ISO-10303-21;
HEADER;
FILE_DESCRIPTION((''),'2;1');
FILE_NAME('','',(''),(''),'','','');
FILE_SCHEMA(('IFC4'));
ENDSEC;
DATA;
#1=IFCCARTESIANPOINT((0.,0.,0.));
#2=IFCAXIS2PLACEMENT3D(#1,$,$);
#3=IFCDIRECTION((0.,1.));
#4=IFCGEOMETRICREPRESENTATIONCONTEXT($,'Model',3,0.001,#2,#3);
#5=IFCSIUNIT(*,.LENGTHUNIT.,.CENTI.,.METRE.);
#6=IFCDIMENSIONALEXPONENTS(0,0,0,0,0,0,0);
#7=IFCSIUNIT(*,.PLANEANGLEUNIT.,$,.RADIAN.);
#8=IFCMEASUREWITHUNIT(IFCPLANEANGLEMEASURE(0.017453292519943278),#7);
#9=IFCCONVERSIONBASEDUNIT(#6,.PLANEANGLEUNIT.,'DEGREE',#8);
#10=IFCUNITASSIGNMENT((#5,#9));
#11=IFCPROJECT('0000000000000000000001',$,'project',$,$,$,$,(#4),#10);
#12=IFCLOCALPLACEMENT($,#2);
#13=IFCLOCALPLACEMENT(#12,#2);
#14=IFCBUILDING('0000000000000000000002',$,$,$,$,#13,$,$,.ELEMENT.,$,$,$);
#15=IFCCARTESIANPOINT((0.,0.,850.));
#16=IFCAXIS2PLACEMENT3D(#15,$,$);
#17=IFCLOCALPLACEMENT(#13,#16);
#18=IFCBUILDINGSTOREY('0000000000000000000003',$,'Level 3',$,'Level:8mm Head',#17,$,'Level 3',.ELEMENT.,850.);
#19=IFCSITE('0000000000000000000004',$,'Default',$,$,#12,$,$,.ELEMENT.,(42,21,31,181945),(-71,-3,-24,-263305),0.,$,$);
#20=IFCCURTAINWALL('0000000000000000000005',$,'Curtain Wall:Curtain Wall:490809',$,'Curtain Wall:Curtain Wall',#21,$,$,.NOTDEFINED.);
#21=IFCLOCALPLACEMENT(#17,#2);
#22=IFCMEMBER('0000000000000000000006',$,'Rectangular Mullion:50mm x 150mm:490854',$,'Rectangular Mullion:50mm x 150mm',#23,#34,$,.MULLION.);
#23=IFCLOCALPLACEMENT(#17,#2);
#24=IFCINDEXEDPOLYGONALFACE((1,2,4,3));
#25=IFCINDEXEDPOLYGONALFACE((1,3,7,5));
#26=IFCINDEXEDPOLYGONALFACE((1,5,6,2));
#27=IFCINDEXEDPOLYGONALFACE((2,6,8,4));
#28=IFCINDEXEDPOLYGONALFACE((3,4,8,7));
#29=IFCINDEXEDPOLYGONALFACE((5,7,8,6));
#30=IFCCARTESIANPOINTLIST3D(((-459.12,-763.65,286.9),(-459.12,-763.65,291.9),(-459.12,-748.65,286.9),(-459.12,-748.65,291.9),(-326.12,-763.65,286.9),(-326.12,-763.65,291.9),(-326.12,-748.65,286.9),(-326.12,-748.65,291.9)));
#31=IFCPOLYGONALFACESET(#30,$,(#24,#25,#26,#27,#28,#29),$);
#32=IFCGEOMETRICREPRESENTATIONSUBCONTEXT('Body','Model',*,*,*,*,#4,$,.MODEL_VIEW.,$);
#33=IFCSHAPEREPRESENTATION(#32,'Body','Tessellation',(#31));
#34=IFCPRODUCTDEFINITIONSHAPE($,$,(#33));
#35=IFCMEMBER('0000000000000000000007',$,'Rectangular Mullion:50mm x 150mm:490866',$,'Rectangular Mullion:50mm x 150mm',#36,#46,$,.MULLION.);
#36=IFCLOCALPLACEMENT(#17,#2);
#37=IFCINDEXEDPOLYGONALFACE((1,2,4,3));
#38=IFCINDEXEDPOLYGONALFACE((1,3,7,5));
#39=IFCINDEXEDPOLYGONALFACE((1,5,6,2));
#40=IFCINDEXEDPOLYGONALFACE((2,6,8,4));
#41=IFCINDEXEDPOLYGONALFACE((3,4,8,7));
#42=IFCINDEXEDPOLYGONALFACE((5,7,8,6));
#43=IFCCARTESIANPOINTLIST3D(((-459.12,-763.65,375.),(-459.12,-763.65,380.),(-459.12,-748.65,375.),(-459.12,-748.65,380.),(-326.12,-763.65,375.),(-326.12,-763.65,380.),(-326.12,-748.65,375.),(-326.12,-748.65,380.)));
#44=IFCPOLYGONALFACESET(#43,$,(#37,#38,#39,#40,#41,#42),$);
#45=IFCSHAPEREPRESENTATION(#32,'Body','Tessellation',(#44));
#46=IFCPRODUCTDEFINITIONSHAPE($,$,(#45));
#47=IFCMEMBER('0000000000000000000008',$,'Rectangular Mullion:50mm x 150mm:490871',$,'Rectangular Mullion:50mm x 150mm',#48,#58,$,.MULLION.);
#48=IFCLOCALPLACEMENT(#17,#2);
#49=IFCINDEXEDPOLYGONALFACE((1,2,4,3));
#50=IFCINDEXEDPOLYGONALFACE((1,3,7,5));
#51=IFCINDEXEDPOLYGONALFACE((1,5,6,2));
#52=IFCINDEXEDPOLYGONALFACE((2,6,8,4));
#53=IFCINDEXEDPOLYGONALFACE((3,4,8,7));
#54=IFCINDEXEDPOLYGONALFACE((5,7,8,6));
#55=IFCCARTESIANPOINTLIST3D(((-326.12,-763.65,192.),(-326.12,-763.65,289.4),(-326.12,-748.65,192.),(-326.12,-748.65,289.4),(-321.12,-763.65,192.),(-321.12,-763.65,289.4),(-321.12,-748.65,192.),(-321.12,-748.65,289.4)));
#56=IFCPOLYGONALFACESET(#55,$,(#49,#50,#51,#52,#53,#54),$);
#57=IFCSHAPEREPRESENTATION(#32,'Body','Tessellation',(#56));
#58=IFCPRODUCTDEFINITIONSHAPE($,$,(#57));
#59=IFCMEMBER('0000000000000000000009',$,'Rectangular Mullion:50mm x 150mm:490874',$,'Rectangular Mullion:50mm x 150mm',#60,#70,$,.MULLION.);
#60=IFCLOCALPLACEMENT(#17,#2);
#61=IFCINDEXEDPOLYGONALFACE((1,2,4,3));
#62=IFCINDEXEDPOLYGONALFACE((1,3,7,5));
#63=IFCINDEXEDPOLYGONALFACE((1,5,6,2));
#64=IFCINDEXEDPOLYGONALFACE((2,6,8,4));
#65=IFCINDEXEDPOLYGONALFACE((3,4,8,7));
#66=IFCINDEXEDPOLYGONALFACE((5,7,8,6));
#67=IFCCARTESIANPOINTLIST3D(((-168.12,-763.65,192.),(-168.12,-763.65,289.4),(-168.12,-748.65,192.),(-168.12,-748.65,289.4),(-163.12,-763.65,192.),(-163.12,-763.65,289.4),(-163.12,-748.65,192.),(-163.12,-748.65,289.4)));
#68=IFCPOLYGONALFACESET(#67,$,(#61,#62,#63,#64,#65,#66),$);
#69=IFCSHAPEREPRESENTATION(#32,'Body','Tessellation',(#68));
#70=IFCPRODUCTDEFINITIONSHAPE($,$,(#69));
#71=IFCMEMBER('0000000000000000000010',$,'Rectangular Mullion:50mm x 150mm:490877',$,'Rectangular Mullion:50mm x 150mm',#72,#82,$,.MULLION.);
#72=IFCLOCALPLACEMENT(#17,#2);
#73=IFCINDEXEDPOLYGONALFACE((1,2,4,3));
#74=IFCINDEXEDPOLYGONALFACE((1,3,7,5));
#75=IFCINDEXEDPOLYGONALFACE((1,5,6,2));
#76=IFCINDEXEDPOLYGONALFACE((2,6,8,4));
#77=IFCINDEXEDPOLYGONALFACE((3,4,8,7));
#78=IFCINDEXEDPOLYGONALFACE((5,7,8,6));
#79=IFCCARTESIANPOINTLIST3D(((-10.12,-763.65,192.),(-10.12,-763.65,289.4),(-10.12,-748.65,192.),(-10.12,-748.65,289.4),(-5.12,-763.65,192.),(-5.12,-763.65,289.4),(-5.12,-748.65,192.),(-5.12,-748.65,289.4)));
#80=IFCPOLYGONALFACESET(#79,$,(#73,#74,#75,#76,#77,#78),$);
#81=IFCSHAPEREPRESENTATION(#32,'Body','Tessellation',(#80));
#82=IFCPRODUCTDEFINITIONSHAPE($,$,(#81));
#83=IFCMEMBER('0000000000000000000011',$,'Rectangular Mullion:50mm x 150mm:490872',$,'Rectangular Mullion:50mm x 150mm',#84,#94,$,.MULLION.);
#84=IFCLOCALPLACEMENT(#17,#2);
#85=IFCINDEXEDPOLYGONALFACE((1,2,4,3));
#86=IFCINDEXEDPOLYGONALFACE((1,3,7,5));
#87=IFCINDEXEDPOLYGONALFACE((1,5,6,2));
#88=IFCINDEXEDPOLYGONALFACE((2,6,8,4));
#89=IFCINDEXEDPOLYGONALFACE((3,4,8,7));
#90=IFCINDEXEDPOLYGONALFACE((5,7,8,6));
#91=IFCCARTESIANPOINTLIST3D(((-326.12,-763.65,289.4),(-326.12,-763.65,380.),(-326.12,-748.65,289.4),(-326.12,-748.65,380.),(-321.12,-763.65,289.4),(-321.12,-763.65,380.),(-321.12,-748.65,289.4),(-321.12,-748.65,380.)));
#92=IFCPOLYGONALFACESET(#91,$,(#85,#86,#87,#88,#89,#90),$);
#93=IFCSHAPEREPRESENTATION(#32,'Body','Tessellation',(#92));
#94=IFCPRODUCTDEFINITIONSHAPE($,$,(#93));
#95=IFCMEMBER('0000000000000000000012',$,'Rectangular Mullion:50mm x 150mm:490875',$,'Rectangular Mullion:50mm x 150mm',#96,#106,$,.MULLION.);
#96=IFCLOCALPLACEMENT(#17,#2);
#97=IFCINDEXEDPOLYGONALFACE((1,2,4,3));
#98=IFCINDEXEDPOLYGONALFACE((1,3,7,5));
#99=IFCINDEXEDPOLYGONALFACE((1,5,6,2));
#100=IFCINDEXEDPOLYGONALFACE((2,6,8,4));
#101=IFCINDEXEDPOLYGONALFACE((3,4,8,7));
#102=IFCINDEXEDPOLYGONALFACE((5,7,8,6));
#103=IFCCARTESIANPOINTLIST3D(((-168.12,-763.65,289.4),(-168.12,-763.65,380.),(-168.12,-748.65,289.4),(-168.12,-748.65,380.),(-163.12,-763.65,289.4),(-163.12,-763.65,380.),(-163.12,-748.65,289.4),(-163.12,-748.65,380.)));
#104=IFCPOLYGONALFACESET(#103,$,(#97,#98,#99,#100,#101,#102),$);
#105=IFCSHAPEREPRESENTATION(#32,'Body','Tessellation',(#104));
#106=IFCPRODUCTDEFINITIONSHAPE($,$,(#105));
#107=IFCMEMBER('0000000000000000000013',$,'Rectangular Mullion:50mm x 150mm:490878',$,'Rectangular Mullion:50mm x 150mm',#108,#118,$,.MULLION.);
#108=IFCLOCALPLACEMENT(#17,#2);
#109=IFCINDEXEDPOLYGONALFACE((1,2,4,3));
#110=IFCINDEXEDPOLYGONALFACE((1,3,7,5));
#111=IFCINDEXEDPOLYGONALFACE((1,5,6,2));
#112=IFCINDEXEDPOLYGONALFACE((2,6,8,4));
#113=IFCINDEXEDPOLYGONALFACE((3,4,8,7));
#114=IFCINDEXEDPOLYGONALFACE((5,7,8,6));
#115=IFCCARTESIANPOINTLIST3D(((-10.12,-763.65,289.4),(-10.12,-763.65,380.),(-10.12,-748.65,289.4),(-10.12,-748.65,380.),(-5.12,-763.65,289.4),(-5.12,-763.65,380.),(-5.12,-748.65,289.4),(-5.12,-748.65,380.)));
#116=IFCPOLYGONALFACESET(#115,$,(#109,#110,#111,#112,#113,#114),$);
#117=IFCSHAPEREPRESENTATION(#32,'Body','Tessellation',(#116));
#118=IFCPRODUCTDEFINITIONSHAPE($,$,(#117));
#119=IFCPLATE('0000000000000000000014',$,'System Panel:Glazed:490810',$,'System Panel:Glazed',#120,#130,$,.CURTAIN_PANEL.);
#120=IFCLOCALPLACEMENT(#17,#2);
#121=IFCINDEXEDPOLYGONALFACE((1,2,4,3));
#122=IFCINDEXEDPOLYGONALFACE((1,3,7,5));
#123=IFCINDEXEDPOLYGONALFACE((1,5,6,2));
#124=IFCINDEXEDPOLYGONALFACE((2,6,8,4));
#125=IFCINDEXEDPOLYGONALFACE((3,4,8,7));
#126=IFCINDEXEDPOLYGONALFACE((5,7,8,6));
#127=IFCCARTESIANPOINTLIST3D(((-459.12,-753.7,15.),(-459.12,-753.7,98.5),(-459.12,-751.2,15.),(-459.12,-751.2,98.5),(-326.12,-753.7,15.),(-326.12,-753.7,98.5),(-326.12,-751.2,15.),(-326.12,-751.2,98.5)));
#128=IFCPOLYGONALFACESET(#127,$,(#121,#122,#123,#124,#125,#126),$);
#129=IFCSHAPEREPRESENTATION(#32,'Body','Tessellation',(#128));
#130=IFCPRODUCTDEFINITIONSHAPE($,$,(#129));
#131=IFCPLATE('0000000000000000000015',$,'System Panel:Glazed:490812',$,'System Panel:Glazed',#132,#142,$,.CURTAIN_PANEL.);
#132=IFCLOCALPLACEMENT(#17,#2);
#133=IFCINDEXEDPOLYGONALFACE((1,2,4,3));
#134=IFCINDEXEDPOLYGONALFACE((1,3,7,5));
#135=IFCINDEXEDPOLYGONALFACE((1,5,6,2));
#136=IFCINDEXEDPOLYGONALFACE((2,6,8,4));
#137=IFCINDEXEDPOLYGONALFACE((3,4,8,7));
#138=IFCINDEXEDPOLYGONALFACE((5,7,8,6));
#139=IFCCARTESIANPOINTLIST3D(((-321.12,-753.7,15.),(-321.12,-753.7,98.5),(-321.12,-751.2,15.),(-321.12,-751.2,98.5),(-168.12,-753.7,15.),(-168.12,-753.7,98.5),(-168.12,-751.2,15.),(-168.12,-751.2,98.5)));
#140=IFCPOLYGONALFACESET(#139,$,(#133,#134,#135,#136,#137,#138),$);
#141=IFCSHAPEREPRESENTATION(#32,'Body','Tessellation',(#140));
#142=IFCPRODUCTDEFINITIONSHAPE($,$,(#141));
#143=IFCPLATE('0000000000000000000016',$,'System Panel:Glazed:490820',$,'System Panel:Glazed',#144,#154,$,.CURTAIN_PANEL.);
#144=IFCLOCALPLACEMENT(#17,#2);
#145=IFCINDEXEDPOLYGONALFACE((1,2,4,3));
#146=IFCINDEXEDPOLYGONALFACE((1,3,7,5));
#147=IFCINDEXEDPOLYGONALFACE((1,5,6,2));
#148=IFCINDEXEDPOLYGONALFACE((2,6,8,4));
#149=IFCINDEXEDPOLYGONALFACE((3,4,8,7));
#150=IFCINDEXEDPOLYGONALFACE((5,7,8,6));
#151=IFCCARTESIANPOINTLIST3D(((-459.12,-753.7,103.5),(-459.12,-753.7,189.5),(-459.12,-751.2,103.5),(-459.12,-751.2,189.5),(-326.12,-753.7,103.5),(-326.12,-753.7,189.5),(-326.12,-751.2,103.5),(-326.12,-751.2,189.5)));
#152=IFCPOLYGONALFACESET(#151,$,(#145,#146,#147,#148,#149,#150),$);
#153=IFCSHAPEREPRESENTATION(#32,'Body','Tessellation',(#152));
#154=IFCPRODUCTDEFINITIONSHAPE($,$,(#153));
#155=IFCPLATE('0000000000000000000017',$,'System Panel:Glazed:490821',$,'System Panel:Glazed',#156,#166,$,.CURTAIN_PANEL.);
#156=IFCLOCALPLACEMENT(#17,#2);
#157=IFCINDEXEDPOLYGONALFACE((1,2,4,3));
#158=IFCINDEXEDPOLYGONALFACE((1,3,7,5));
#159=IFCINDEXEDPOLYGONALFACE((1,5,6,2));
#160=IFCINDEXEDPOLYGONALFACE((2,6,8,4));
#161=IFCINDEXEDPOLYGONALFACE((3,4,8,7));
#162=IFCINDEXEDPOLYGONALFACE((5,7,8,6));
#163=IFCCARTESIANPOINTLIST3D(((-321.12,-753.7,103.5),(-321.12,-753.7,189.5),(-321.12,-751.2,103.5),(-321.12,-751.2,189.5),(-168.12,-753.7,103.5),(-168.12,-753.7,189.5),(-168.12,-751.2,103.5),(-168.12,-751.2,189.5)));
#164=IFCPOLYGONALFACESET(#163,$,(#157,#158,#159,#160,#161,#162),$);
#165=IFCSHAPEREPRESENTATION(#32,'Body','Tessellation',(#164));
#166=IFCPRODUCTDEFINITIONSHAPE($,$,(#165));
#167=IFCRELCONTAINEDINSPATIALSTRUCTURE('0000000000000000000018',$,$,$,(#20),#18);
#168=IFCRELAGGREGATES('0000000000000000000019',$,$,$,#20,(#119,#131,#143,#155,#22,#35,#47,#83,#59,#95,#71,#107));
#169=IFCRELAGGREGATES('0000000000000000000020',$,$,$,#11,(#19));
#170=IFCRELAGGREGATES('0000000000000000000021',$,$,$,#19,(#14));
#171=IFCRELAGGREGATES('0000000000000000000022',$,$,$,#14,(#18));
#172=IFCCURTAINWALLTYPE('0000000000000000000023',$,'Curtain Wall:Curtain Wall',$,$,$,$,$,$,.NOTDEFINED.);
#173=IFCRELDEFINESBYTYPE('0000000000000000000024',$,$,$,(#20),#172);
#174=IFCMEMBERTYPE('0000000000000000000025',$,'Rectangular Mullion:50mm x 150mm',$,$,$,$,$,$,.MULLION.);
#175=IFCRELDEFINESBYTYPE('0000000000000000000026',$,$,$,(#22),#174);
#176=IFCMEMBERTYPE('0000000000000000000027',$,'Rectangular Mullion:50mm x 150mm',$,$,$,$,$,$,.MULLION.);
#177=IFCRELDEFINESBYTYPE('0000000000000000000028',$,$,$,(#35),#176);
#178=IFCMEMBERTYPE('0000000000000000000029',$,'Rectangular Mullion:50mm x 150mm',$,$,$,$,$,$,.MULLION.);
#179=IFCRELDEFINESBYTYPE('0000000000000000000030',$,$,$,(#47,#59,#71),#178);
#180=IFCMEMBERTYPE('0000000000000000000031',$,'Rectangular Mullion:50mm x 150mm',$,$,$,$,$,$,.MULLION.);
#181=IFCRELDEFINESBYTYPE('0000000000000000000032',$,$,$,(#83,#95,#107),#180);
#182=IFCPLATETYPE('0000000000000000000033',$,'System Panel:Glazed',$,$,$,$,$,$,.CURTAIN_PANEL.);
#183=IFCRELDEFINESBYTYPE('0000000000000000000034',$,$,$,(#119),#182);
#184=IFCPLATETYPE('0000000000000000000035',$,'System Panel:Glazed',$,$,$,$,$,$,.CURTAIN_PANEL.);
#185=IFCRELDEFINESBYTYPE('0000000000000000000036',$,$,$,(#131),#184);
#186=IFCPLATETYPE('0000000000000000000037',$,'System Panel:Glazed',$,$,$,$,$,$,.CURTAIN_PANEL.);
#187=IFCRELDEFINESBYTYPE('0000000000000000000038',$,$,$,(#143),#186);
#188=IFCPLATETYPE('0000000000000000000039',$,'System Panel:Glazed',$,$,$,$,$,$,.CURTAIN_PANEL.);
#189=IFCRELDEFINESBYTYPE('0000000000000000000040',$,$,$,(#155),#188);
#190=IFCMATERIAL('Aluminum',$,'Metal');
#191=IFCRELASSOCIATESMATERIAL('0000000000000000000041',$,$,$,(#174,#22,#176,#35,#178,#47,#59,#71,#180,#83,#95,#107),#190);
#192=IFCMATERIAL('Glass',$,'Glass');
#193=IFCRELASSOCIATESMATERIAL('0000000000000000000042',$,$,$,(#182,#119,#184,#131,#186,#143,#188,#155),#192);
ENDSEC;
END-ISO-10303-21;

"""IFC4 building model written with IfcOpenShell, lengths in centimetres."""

from ifc_helpers import new_model, entity, si_unit, converted_unit, direction, frame, origin, place, context, subcontext, project, spatial, indexed_curve, outline, extrude, source, transform, mapped, material, type_object, type_shapes, element, aggregate, save


model = new_model("IFC4")

# Units and contexts
model_context = context("Model", 3, precision=0.001, world=origin(), true_north=direction((0.0, 1.0)))
body_context = subcontext(model_context, "Body", "Model", "MODEL_VIEW")
ifc_project = project(units=[si_unit("LENGTHUNIT", "METRE", prefix="CENTI"), converted_unit("PLANEANGLEUNIT", "DEGREE", entity("IfcPlaneAngleMeasure", 0.017453292519943278), si_unit("PLANEANGLEUNIT", "RADIAN"), dimensions=[0, 0, 0, 0, 0, 0, 0])], contexts=[model_context])

# Site, building, storey
site_placement = place(None, origin())
site = spatial("IfcSite", under=ifc_project, at=site_placement, Name="Default", CompositionType="ELEMENT", RefLatitude=(42, 21, 31, 181945), RefLongitude=(-71, -3, -24, -263305), RefElevation=0.0)
building_placement = place(site_placement, origin())
building = spatial("IfcBuilding", under=site, at=building_placement, CompositionType="ELEMENT")
storey_placement = place(building_placement, frame((0.0, 0.0, 850.0)))
storey = spatial("IfcBuildingStorey", under=building, at=storey_placement, Name="Level 3", ObjectType="Level:8mm Head", LongName="Level 3", CompositionType="ELEMENT", Elevation=850.0)

# Curtain wall, members, plates
curtain_wall_type = type_object("IfcCurtainWallType", Name="Curtain Wall:Curtain Wall", PredefinedType="NOTDEFINED")
curtain_wall_placement = place(storey_placement, frame((0.0, 0.0, -850.0)))
curtain_wall = element("IfcCurtainWall", 1, at=curtain_wall_placement, inside=storey, type_object=curtain_wall_type, Name="Curtain Wall:Curtain Wall:490809", ObjectType="Curtain Wall:Curtain Wall", PredefinedType="NOTDEFINED")
ifc_material_1 = material(Name="Aluminum", Category="Metal")
member_type_1 = type_object("IfcMemberType", Name="Rectangular Mullion:50mm x 150mm", PredefinedType="MULLION", material=ifc_material_1)
shared_shape_1 = source(origin(), body_context, "Body", "SweptSolid", [
    extrude(outline(indexed_curve([(-2.5, -7.5), (2.5, -7.5), (2.5, 7.5), (-2.5, 7.5), (-2.5, -7.5)], self_intersect=False)), frame((0.0, 0.0, -133.0), z_axis=(0.0, 0.0, 1.0), x_axis=(-1.0, 0.0, 0.0)), (0.0, 0.0, 1.0), 133.0),
])
type_shapes(member_type_1, [shared_shape_1])
member_1_placement = place(curtain_wall_placement, frame((-326.12, -756.15, 1139.4), z_axis=(1.0, 0.0, 0.0), x_axis=(0.0, 0.0, 1.0)))
member_1 = element("IfcMember", 2, at=member_1_placement, type_object=member_type_1, material=ifc_material_1, Name="Rectangular Mullion:50mm x 150mm:490854", ObjectType="Rectangular Mullion:50mm x 150mm", PredefinedType="MULLION", context=body_context, shape_type="MappedRepresentation", body=[
    mapped(shared_shape_1, transform((0.0, 0.0, 0.0), scale=1.0)),
])
member_type_2 = type_object("IfcMemberType", Name="Rectangular Mullion:50mm x 150mm", PredefinedType="MULLION", material=ifc_material_1)
shared_shape_2 = source(origin(), body_context, "Body", "SweptSolid", [
    extrude(outline(indexed_curve([(-2.5, -7.5), (2.5, -7.5), (2.5, 7.5), (-2.5, 7.5), (-2.5, -7.5)], self_intersect=False)), frame((-2.5, 0.0, -133.0), z_axis=(0.0, 0.0, 1.0), x_axis=(-1.0, 0.0, 0.0)), (0.0, 0.0, 1.0), 133.0),
])
type_shapes(member_type_2, [shared_shape_2])
member_2_placement = place(curtain_wall_placement, frame((-326.12, -756.15, 1230.0), z_axis=(1.0, 0.0, 0.0), x_axis=(0.0, 0.0, 1.0)))
member_2 = element("IfcMember", 3, at=member_2_placement, type_object=member_type_2, material=ifc_material_1, Name="Rectangular Mullion:50mm x 150mm:490866", ObjectType="Rectangular Mullion:50mm x 150mm", PredefinedType="MULLION", context=body_context, shape_type="MappedRepresentation", body=[
    mapped(shared_shape_2, transform((0.0, 0.0, 0.0), scale=1.0)),
])
member_type_3 = type_object("IfcMemberType", Name="Rectangular Mullion:50mm x 150mm", PredefinedType="MULLION", material=ifc_material_1)
shared_shape_3 = source(origin(), body_context, "Body", "SweptSolid", [
    extrude(outline(indexed_curve([(-2.5, -7.5), (2.5, -7.5), (2.5, 7.5), (-2.5, 7.5), (-2.5, -7.5)], self_intersect=False)), frame((0.0, 0.0, -97.4), z_axis=(0.0, 0.0, 1.0), x_axis=(-1.0, 0.0, 0.0)), (0.0, 0.0, 1.0), 97.4),
])
type_shapes(member_type_3, [shared_shape_3])
member_3_placement = place(curtain_wall_placement, frame((-323.62, -756.15, 1042.0), z_axis=(0.0, 0.0, -1.0), x_axis=(1.0, 0.0, 0.0)))
member_3 = element("IfcMember", 4, at=member_3_placement, type_object=member_type_3, material=ifc_material_1, Name="Rectangular Mullion:50mm x 150mm:490871", ObjectType="Rectangular Mullion:50mm x 150mm", PredefinedType="MULLION", context=body_context, shape_type="MappedRepresentation", body=[
    mapped(shared_shape_3, transform((0.0, 0.0, 0.0), scale=1.0)),
])
member_4_placement = place(curtain_wall_placement, frame((-165.62, -756.15, 1042.0), z_axis=(0.0, 0.0, -1.0), x_axis=(1.0, 0.0, 0.0)))
member_4 = element("IfcMember", 5, at=member_4_placement, type_object=member_type_3, material=ifc_material_1, Name="Rectangular Mullion:50mm x 150mm:490874", ObjectType="Rectangular Mullion:50mm x 150mm", PredefinedType="MULLION", context=body_context, shape_type="MappedRepresentation", body=[
    mapped(shared_shape_3, transform((0.0, 0.0, 0.0), scale=1.0)),
])
member_5_placement = place(curtain_wall_placement, frame((-7.62, -756.15, 1042.0), z_axis=(0.0, 0.0, -1.0), x_axis=(1.0, 0.0, 0.0)))
member_5 = element("IfcMember", 6, at=member_5_placement, type_object=member_type_3, material=ifc_material_1, Name="Rectangular Mullion:50mm x 150mm:490877", ObjectType="Rectangular Mullion:50mm x 150mm", PredefinedType="MULLION", context=body_context, shape_type="MappedRepresentation", body=[
    mapped(shared_shape_3, transform((0.0, 0.0, 0.0), scale=1.0)),
])
member_type_4 = type_object("IfcMemberType", Name="Rectangular Mullion:50mm x 150mm", PredefinedType="MULLION", material=ifc_material_1)
shared_shape_4 = source(origin(), body_context, "Body", "SweptSolid", [
    extrude(outline(indexed_curve([(-2.5, -7.5), (2.5, -7.5), (2.5, 7.5), (-2.5, 7.5), (-2.5, -7.5)], self_intersect=False)), frame((0.0, 0.0, -90.6), z_axis=(0.0, 0.0, 1.0), x_axis=(-1.0, 0.0, 0.0)), (0.0, 0.0, 1.0), 90.6),
])
type_shapes(member_type_4, [shared_shape_4])
member_6_placement = place(curtain_wall_placement, frame((-323.62, -756.15, 1139.4), z_axis=(0.0, 0.0, -1.0), x_axis=(1.0, 0.0, 0.0)))
member_6 = element("IfcMember", 7, at=member_6_placement, type_object=member_type_4, material=ifc_material_1, Name="Rectangular Mullion:50mm x 150mm:490872", ObjectType="Rectangular Mullion:50mm x 150mm", PredefinedType="MULLION", context=body_context, shape_type="MappedRepresentation", body=[
    mapped(shared_shape_4, transform((0.0, 0.0, 0.0), scale=1.0)),
])
member_7_placement = place(curtain_wall_placement, frame((-165.62, -756.15, 1139.4), z_axis=(0.0, 0.0, -1.0), x_axis=(1.0, 0.0, 0.0)))
member_7 = element("IfcMember", 8, at=member_7_placement, type_object=member_type_4, material=ifc_material_1, Name="Rectangular Mullion:50mm x 150mm:490875", ObjectType="Rectangular Mullion:50mm x 150mm", PredefinedType="MULLION", context=body_context, shape_type="MappedRepresentation", body=[
    mapped(shared_shape_4, transform((0.0, 0.0, 0.0), scale=1.0)),
])
member_8_placement = place(curtain_wall_placement, frame((-7.62, -756.15, 1139.4), z_axis=(0.0, 0.0, -1.0), x_axis=(1.0, 0.0, 0.0)))
member_8 = element("IfcMember", 9, at=member_8_placement, type_object=member_type_4, material=ifc_material_1, Name="Rectangular Mullion:50mm x 150mm:490878", ObjectType="Rectangular Mullion:50mm x 150mm", PredefinedType="MULLION", context=body_context, shape_type="MappedRepresentation", body=[
    mapped(shared_shape_4, transform((0.0, 0.0, 0.0), scale=1.0)),
])
ifc_material_2 = material(Name="Glass", Category="Glass")
plate_type_1 = type_object("IfcPlateType", Name="System Panel:Glazed", PredefinedType="CURTAIN_PANEL", material=ifc_material_2)
shared_shape_5 = source(origin(), body_context, "Body", "SweptSolid", [
    extrude(outline(indexed_curve([(-1.25, -66.5), (1.25, -66.5), (1.25, 66.5), (-1.25, 66.5), (-1.25, -66.5)], self_intersect=False)), frame((0.0, 3.7, 0.0), z_axis=(0.0, 0.0, 1.0), x_axis=(0.0, 1.0, 0.0)), (0.0, 0.0, 1.0), 83.5),
])
type_shapes(plate_type_1, [shared_shape_5])
plate_1_placement = place(curtain_wall_placement, frame((-392.62, -756.15, 865.0)))
plate_1 = element("IfcPlate", 10, at=plate_1_placement, type_object=plate_type_1, material=ifc_material_2, Name="System Panel:Glazed:490810", ObjectType="System Panel:Glazed", PredefinedType="CURTAIN_PANEL", context=body_context, shape_type="MappedRepresentation", body=[
    mapped(shared_shape_5, transform((0.0, 0.0, 0.0), scale=1.0)),
])
plate_type_2 = type_object("IfcPlateType", Name="System Panel:Glazed", PredefinedType="CURTAIN_PANEL", material=ifc_material_2)
shared_shape_6 = source(origin(), body_context, "Body", "SweptSolid", [
    extrude(outline(indexed_curve([(-1.25, -76.5), (1.25, -76.5), (1.25, 76.5), (-1.25, 76.5), (-1.25, -76.5)], self_intersect=False)), frame((0.0, 3.7, 0.0), z_axis=(0.0, 0.0, 1.0), x_axis=(0.0, 1.0, 0.0)), (0.0, 0.0, 1.0), 83.5),
])
type_shapes(plate_type_2, [shared_shape_6])
plate_2_placement = place(curtain_wall_placement, frame((-244.62, -756.15, 865.0)))
plate_2 = element("IfcPlate", 11, at=plate_2_placement, type_object=plate_type_2, material=ifc_material_2, Name="System Panel:Glazed:490812", ObjectType="System Panel:Glazed", PredefinedType="CURTAIN_PANEL", context=body_context, shape_type="MappedRepresentation", body=[
    mapped(shared_shape_6, transform((0.0, 0.0, 0.0), scale=1.0)),
])
plate_type_3 = type_object("IfcPlateType", Name="System Panel:Glazed", PredefinedType="CURTAIN_PANEL", material=ifc_material_2)
shared_shape_7 = source(origin(), body_context, "Body", "SweptSolid", [
    extrude(outline(indexed_curve([(-1.25, -66.5), (1.25, -66.5), (1.25, 66.5), (-1.25, 66.5), (-1.25, -66.5)], self_intersect=False)), frame((0.0, 3.7, 0.0), z_axis=(0.0, 0.0, 1.0), x_axis=(0.0, 1.0, 0.0)), (0.0, 0.0, 1.0), 86.0),
])
type_shapes(plate_type_3, [shared_shape_7])
plate_3_placement = place(curtain_wall_placement, frame((-392.62, -756.15, 953.5)))
plate_3 = element("IfcPlate", 12, at=plate_3_placement, type_object=plate_type_3, material=ifc_material_2, Name="System Panel:Glazed:490820", ObjectType="System Panel:Glazed", PredefinedType="CURTAIN_PANEL", context=body_context, shape_type="MappedRepresentation", body=[
    mapped(shared_shape_7, transform((0.0, 0.0, 0.0), scale=1.0)),
])
plate_type_4 = type_object("IfcPlateType", Name="System Panel:Glazed", PredefinedType="CURTAIN_PANEL", material=ifc_material_2)
shared_shape_8 = source(origin(), body_context, "Body", "SweptSolid", [
    extrude(outline(indexed_curve([(-1.25, -76.5), (1.25, -76.5), (1.25, 76.5), (-1.25, 76.5), (-1.25, -76.5)], self_intersect=False)), frame((0.0, 3.7, 0.0), z_axis=(0.0, 0.0, 1.0), x_axis=(0.0, 1.0, 0.0)), (0.0, 0.0, 1.0), 86.0),
])
type_shapes(plate_type_4, [shared_shape_8])
plate_4_placement = place(curtain_wall_placement, frame((-244.62, -756.15, 953.5)))
plate_4 = element("IfcPlate", 13, at=plate_4_placement, type_object=plate_type_4, material=ifc_material_2, Name="System Panel:Glazed:490821", ObjectType="System Panel:Glazed", PredefinedType="CURTAIN_PANEL", context=body_context, shape_type="MappedRepresentation", body=[
    mapped(shared_shape_8, transform((0.0, 0.0, 0.0), scale=1.0)),
])
aggregate(curtain_wall, [plate_1, plate_2, plate_3, plate_4, member_1, member_2, member_3, member_6, member_4, member_7, member_5, member_8])

save(model, "model.ifc")
